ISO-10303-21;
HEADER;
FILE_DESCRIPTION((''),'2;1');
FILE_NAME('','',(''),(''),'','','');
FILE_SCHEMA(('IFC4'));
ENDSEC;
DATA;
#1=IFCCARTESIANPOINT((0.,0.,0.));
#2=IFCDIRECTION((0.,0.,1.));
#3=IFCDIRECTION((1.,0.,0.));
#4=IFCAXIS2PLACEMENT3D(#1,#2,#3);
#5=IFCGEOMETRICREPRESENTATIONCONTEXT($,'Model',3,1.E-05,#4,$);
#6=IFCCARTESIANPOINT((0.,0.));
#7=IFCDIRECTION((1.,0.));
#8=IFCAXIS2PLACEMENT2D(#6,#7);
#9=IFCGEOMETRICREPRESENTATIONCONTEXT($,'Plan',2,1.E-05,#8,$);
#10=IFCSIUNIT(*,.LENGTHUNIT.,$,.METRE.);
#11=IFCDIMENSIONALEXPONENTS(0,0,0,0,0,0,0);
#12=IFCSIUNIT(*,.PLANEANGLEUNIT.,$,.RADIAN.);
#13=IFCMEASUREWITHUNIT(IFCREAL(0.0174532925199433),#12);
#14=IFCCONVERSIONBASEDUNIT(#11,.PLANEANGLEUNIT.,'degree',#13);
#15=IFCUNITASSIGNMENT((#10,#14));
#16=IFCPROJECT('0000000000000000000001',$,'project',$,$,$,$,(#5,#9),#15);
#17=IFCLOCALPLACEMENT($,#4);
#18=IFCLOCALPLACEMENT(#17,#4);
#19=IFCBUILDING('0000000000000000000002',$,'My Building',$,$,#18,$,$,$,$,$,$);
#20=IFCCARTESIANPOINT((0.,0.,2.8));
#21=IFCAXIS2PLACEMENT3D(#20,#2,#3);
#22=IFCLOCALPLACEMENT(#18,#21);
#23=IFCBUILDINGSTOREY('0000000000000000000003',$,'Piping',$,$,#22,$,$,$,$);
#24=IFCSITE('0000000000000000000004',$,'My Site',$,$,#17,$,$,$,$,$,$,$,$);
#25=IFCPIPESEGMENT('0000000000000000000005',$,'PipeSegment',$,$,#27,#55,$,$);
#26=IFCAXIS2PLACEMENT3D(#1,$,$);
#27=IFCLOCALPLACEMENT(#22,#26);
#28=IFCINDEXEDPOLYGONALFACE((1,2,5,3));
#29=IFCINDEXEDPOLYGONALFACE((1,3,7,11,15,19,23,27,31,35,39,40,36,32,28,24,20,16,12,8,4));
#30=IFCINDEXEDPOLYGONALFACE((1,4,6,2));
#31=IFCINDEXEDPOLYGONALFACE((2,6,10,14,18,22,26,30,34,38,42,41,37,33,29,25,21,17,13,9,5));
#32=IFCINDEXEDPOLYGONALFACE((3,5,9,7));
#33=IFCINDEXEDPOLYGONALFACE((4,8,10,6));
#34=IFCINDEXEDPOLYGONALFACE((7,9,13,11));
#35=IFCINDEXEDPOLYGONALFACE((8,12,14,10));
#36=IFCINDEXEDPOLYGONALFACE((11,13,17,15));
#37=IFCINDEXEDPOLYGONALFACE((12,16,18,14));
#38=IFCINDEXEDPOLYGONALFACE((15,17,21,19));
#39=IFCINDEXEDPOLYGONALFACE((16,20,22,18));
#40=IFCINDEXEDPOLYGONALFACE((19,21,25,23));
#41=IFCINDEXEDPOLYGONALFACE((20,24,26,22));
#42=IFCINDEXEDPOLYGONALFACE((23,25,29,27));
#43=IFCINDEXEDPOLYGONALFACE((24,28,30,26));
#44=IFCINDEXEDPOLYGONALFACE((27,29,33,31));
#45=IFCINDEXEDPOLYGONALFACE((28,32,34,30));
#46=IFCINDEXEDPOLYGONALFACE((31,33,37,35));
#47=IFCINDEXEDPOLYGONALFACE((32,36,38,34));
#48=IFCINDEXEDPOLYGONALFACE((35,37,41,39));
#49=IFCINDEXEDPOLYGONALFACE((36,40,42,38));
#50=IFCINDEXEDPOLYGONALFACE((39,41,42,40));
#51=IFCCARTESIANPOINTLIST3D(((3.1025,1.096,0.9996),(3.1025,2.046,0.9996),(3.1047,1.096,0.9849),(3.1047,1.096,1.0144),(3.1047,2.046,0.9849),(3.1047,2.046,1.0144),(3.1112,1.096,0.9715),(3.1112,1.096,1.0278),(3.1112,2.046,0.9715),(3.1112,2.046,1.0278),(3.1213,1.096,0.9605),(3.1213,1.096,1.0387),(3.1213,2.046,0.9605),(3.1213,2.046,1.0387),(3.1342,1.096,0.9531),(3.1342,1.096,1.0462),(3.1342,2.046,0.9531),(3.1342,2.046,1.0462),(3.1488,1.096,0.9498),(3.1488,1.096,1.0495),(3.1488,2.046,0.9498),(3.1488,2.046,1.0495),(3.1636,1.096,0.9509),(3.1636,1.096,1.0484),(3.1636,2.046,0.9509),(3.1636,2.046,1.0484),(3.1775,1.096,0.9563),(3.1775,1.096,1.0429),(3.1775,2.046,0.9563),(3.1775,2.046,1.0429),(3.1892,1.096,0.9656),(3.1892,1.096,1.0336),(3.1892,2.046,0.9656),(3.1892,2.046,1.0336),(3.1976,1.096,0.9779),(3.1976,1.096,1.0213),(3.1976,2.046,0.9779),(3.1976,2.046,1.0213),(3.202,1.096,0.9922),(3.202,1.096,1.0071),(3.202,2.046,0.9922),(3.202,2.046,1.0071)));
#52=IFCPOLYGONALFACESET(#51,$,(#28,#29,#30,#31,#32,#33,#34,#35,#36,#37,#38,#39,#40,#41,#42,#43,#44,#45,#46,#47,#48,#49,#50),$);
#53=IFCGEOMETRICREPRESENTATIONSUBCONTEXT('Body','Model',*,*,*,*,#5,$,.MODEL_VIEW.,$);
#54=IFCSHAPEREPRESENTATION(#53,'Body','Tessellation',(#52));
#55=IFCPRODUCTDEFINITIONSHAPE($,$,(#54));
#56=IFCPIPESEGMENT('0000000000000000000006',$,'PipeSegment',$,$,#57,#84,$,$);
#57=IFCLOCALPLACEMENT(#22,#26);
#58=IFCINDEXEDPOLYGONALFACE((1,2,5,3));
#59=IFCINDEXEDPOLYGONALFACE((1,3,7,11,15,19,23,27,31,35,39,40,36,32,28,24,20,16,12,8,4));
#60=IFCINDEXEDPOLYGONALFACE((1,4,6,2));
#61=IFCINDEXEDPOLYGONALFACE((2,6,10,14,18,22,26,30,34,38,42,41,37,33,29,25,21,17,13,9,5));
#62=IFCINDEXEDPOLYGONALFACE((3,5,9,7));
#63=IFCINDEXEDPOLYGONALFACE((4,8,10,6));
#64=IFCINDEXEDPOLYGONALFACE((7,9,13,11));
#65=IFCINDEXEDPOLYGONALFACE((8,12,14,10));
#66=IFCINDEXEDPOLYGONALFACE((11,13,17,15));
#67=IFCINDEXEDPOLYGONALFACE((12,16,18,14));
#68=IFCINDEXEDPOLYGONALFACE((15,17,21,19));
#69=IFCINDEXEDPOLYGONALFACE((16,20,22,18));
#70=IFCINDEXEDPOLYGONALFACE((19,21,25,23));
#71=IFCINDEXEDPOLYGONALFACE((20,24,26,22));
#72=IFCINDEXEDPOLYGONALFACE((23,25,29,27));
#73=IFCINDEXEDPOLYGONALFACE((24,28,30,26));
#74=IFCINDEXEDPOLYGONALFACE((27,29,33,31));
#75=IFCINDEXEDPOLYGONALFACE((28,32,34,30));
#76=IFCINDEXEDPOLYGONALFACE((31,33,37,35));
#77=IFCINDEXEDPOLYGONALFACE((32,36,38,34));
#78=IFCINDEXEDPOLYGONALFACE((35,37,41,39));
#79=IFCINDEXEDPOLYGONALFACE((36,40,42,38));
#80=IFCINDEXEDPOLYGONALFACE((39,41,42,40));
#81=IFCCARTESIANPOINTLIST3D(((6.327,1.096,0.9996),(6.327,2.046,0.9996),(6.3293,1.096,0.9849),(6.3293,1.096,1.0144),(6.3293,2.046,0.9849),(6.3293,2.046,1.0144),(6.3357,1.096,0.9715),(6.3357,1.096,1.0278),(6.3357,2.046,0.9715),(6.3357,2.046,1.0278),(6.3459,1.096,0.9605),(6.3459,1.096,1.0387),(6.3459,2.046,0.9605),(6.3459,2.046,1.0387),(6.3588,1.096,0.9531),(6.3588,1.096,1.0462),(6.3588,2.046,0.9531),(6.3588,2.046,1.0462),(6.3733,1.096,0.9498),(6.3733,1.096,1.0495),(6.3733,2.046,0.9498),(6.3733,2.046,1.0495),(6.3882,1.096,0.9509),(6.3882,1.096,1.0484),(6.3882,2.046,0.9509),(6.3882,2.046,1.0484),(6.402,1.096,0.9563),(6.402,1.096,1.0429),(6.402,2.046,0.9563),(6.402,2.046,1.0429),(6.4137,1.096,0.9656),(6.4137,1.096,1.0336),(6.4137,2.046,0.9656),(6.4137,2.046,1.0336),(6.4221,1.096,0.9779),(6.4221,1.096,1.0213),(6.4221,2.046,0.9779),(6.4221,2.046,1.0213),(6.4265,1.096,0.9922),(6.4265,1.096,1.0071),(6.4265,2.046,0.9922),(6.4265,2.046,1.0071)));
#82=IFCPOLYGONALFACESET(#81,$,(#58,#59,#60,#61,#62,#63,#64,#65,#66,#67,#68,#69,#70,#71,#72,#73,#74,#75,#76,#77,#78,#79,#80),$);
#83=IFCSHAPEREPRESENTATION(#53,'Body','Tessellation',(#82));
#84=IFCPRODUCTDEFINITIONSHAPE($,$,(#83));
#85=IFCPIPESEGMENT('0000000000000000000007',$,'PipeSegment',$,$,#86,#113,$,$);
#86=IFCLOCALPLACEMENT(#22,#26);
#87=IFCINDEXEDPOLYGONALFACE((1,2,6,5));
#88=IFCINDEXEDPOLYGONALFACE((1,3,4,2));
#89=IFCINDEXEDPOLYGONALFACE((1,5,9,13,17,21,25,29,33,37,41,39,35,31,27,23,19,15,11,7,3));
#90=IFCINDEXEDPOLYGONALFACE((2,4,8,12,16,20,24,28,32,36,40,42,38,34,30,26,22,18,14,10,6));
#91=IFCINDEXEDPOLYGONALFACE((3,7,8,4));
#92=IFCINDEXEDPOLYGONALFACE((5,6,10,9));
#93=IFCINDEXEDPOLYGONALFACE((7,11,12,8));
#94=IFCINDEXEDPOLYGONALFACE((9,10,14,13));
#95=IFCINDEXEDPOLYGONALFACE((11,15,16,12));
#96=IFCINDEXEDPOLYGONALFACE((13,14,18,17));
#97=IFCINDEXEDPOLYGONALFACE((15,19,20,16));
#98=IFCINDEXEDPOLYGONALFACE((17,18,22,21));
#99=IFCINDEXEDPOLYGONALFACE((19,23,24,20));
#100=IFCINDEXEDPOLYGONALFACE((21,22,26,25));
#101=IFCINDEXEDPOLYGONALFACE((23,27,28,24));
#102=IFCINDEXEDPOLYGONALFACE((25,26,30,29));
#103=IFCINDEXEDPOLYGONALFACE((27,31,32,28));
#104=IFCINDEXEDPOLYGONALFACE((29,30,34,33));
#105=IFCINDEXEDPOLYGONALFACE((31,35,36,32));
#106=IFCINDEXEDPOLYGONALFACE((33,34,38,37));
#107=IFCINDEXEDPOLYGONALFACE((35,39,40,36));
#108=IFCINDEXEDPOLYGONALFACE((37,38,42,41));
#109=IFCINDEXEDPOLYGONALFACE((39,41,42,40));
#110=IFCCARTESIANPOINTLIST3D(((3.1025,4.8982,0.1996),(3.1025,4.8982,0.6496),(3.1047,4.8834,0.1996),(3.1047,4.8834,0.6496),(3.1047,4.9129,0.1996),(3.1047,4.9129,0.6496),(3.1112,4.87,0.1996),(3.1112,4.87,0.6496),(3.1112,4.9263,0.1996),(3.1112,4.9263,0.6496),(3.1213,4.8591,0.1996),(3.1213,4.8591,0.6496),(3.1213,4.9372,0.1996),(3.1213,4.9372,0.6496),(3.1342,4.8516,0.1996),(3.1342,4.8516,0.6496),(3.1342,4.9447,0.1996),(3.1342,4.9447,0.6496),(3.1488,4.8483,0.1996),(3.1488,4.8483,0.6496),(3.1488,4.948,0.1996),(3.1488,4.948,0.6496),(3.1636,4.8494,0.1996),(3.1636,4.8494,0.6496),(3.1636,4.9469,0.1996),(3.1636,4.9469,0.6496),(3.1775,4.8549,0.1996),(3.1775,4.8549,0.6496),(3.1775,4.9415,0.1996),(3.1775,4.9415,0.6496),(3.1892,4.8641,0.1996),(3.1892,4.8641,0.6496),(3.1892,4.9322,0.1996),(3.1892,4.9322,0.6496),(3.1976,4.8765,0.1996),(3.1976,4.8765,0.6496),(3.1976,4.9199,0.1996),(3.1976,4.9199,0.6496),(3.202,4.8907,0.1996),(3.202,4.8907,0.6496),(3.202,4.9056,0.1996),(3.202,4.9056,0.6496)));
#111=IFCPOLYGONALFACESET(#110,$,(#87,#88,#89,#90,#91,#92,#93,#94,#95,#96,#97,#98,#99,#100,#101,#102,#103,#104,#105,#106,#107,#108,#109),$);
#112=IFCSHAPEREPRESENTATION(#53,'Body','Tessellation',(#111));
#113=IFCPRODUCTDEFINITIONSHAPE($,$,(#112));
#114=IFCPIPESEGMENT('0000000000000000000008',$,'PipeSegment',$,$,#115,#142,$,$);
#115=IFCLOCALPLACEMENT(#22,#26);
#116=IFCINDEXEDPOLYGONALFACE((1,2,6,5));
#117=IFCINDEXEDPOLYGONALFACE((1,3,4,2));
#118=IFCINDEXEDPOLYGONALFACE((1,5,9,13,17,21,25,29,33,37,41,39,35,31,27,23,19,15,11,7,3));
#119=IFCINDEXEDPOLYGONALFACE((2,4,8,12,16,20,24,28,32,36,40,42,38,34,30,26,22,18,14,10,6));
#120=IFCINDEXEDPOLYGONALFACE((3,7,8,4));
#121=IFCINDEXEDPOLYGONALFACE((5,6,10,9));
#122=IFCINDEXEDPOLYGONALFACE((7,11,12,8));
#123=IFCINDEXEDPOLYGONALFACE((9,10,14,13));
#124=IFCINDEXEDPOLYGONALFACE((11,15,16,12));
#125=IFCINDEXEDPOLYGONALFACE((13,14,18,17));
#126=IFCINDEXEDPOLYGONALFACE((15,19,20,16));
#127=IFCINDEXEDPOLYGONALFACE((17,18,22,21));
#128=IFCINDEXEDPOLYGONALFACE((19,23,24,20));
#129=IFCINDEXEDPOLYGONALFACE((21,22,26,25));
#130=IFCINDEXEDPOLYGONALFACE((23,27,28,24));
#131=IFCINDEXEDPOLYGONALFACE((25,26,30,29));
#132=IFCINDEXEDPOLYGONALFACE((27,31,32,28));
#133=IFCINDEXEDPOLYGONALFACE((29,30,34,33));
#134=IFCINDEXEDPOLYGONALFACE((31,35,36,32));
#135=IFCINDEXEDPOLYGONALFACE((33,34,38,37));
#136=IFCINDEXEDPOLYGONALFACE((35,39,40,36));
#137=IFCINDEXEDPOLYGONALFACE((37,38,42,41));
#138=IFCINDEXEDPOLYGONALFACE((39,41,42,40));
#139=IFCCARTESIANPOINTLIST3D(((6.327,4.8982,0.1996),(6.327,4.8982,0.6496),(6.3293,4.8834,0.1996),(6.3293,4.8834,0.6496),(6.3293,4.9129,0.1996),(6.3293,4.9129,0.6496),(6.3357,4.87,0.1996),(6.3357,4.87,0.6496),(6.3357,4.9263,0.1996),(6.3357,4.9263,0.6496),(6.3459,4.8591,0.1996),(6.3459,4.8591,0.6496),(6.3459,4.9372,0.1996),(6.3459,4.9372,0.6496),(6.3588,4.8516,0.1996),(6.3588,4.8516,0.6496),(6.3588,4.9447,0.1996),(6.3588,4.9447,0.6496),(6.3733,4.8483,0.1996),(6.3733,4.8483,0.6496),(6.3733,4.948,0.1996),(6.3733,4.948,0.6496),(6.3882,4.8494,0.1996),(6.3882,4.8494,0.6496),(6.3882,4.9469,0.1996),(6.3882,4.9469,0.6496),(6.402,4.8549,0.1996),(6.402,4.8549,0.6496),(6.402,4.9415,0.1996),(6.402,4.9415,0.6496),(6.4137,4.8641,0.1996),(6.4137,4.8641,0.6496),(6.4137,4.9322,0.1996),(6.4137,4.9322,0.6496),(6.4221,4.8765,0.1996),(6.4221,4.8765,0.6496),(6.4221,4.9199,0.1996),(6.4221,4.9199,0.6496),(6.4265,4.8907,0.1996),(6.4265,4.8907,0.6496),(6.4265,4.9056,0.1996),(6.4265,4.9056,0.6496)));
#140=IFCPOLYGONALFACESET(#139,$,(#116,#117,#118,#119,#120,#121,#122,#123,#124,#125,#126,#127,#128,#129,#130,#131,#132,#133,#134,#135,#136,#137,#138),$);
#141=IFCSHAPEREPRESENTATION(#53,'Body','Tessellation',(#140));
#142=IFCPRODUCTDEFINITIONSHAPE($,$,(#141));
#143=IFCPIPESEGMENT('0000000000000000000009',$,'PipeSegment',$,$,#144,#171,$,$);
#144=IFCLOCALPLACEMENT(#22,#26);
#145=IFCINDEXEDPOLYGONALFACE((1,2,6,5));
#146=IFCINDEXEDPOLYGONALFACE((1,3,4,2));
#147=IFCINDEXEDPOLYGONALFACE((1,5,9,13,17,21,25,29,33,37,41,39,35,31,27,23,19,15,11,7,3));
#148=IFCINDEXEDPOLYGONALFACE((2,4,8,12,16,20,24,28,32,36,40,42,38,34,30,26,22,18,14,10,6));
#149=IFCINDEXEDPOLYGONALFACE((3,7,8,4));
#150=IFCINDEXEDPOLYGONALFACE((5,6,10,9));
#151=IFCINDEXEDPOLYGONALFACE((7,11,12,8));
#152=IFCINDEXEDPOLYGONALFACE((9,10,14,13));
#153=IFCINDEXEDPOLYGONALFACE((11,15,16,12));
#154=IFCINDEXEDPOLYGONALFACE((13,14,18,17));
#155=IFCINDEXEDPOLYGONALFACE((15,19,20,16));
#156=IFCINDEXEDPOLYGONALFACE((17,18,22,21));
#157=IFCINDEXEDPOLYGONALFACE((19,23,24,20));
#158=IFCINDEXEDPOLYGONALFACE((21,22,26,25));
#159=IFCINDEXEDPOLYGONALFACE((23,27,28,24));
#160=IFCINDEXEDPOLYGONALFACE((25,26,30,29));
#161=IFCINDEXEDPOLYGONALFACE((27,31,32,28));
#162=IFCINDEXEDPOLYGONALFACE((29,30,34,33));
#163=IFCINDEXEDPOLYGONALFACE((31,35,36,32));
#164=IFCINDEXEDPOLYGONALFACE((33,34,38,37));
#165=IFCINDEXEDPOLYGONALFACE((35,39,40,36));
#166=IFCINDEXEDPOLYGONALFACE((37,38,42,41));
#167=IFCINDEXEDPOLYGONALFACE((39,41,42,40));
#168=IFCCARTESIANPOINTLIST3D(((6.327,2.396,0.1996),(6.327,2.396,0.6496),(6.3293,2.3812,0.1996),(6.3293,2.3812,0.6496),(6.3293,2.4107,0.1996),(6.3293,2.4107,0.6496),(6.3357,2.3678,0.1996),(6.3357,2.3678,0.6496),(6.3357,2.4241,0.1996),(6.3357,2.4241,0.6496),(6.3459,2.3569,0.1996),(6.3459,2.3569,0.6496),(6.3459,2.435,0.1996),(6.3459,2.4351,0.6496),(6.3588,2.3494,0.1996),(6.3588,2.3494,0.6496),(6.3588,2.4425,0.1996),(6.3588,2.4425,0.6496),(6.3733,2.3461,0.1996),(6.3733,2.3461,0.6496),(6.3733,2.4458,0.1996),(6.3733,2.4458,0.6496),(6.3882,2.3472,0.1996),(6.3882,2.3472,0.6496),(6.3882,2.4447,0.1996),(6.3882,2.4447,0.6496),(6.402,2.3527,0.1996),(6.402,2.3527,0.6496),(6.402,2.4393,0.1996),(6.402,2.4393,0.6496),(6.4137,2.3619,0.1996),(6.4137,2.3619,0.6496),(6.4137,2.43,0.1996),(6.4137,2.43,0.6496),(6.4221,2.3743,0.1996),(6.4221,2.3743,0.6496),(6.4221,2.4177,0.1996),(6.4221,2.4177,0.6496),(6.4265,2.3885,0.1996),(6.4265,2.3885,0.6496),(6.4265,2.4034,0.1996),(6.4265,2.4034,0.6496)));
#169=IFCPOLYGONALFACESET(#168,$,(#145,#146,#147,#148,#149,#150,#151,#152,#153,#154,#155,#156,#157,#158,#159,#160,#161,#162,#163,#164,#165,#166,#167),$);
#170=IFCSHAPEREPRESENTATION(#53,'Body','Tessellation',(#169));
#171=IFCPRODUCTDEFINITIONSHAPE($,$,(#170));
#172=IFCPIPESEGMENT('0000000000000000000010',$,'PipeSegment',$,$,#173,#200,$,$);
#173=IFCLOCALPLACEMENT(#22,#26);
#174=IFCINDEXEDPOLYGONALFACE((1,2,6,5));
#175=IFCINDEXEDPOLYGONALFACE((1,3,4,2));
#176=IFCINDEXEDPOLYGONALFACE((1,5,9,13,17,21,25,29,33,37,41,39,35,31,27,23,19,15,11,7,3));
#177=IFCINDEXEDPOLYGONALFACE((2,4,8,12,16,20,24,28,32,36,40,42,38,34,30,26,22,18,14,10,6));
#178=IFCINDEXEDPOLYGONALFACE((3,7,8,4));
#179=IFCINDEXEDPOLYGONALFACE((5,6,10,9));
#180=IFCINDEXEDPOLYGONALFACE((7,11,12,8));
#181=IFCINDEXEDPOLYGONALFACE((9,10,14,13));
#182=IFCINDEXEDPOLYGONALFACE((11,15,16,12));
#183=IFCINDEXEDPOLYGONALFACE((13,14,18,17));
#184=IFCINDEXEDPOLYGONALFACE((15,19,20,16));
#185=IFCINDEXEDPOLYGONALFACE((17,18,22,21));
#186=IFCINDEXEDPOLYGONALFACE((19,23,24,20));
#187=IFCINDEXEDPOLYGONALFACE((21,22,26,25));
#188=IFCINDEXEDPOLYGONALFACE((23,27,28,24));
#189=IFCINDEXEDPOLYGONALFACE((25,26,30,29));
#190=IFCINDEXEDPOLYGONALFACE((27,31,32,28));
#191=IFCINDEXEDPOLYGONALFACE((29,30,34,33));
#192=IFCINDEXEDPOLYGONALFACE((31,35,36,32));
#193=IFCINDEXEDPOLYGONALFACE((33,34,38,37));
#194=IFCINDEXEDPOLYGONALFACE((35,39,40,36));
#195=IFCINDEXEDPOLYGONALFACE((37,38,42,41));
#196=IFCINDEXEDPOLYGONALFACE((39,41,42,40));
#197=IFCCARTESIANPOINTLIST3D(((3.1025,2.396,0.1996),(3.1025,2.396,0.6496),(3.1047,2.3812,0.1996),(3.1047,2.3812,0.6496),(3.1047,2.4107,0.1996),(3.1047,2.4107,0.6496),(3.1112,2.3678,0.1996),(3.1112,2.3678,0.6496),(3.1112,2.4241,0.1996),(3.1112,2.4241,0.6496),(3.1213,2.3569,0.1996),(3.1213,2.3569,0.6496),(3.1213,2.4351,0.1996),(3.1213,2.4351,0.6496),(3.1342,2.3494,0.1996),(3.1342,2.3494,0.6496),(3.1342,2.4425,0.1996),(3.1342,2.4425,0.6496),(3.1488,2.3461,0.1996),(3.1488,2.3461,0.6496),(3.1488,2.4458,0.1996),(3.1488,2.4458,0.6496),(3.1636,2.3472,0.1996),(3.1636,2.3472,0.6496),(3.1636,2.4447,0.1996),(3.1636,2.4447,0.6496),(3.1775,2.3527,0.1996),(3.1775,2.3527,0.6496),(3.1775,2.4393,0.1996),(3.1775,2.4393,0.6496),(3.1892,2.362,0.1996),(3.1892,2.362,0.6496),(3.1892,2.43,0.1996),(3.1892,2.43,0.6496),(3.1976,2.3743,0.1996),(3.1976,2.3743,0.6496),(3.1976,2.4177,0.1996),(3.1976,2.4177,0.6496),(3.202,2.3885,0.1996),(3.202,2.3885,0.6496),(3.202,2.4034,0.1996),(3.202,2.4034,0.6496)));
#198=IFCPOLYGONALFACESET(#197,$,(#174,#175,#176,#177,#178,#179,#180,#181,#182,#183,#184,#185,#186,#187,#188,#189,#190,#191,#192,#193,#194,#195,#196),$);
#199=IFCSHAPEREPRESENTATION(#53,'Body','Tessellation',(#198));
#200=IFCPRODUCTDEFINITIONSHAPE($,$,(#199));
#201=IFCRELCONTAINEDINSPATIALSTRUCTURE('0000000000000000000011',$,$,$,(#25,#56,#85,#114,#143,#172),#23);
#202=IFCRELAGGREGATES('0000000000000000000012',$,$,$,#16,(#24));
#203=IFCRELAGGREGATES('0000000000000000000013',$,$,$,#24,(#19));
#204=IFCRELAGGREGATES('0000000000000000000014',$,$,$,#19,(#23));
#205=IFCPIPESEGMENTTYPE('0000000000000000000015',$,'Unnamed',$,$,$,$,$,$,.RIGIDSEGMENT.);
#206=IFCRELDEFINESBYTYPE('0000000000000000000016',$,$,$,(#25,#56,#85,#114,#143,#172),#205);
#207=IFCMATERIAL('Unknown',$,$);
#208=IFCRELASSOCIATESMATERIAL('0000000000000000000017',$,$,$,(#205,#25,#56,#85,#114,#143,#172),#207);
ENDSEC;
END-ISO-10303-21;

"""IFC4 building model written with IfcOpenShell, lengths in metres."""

from ifc_helpers import new_model, entity, si_unit, converted_unit, frame, origin_with_axes, origin_2d_with_axis, place, context, subcontext, project, spatial, circle, extrude, material, material_profile, profile_set, profile_usage, type_object, element, save


model = new_model("IFC4")

# Units and contexts
model_context = context("Model", 3, precision=1e-05, world=origin_with_axes())
plan_context = context("Plan", 2, precision=1e-05, world=origin_2d_with_axis())
body_context = subcontext(model_context, "Body", "Model", "MODEL_VIEW")
ifc_project = project(units=[si_unit("LENGTHUNIT", "METRE"), converted_unit("PLANEANGLEUNIT", "degree", entity("IfcReal", 0.0174532925199433), si_unit("PLANEANGLEUNIT", "RADIAN"), dimensions=[0, 0, 0, 0, 0, 0, 0])], contexts=[model_context, plan_context])

# Site, building, storey
site_placement = place(None, origin_with_axes())
site = spatial("IfcSite", under=ifc_project, at=site_placement, Name="My Site")
building_placement = place(site_placement, origin_with_axes())
building = spatial("IfcBuilding", under=site, at=building_placement, Name="My Building")
storey_placement = place(building_placement, frame((0.0, 0.0, 2.8), z_axis=(0.0, 0.0, 1.0), x_axis=(1.0, 0.0, 0.0)))
storey = spatial("IfcBuildingStorey", under=building, at=storey_placement, Name="Piping")

# Pipe segments
ifc_material = material(Name="Unknown")
ifc_material_profile_1 = material_profile(ifc_material, circle(Radius=0.05))
ifc_profile_set_1 = profile_set([ifc_material_profile_1])
pipe_segment_type = type_object("IfcPipeSegmentType", Name="Unnamed", PredefinedType="RIGIDSEGMENT", material=ifc_profile_set_1)
ifc_profile_usage_1 = profile_usage(ifc_profile_set_1, cardinal=5)
pipe_segment_1_placement = place(storey_placement, frame((3.1525, 1.096, 0.9996), z_axis=(0.0, 1.0, 0.0), x_axis=(-1.0, 0.0, 0.0)))
element("IfcPipeSegment", 1, at=pipe_segment_1_placement, inside=storey, type_object=pipe_segment_type, material=ifc_profile_usage_1, Name="PipeSegment", context=body_context, shape_type="SweptSolid", body=[
    extrude(circle(Radius=0.05), origin_with_axes(), (0.0, 0.0, 1.0), 0.95),
])
ifc_profile_usage_2 = profile_usage(ifc_profile_set_1, cardinal=5)
pipe_segment_2_placement = place(storey_placement, frame((6.377, 1.096, 0.9996), z_axis=(0.0, 1.0, 0.0), x_axis=(-1.0, 0.0, 0.0)))
element("IfcPipeSegment", 2, at=pipe_segment_2_placement, inside=storey, type_object=pipe_segment_type, material=ifc_profile_usage_2, Name="PipeSegment", context=body_context, shape_type="SweptSolid", body=[
    extrude(circle(Radius=0.05), origin_with_axes(), (0.0, 0.0, 1.0), 0.95),
])
ifc_profile_usage_3 = profile_usage(ifc_profile_set_1, cardinal=5)
pipe_segment_3_placement = place(storey_placement, frame((3.1525, 4.8982, 0.6496), z_axis=(0.0, 0.0, -1.0), x_axis=(-1.0, 0.0, 0.0)))
element("IfcPipeSegment", 3, at=pipe_segment_3_placement, inside=storey, type_object=pipe_segment_type, material=ifc_profile_usage_3, Name="PipeSegment", context=body_context, shape_type="SweptSolid", body=[
    extrude(circle(Radius=0.05), origin_with_axes(), (0.0, 0.0, 1.0), 0.45),
])
ifc_profile_usage_4 = profile_usage(ifc_profile_set_1, cardinal=5)
pipe_segment_4_placement = place(storey_placement, frame((6.377, 4.8982, 0.6496), z_axis=(0.0, 0.0, -1.0), x_axis=(-1.0, 0.0, 0.0)))
element("IfcPipeSegment", 4, at=pipe_segment_4_placement, inside=storey, type_object=pipe_segment_type, material=ifc_profile_usage_4, Name="PipeSegment", context=body_context, shape_type="SweptSolid", body=[
    extrude(circle(Radius=0.05), origin_with_axes(), (0.0, 0.0, 1.0), 0.45),
])
ifc_profile_usage_5 = profile_usage(ifc_profile_set_1, cardinal=5)
pipe_segment_5_placement = place(storey_placement, frame((6.377, 2.396, 0.6496), z_axis=(0.0, 0.0, -1.0), x_axis=(-1.0, 0.0, 0.0)))
element("IfcPipeSegment", 5, at=pipe_segment_5_placement, inside=storey, type_object=pipe_segment_type, material=ifc_profile_usage_5, Name="PipeSegment", context=body_context, shape_type="SweptSolid", body=[
    extrude(circle(Radius=0.05), origin_with_axes(), (0.0, 0.0, 1.0), 0.45),
])
ifc_profile_usage_6 = profile_usage(ifc_profile_set_1, cardinal=5)
pipe_segment_6_placement = place(storey_placement, frame((3.1525, 2.396, 0.6496), z_axis=(0.0, 0.0, -1.0), x_axis=(-1.0, 0.0, 0.0)))
element("IfcPipeSegment", 6, at=pipe_segment_6_placement, inside=storey, type_object=pipe_segment_type, material=ifc_profile_usage_6, Name="PipeSegment", context=body_context, shape_type="SweptSolid", body=[
    extrude(circle(Radius=0.05), origin_with_axes(), (0.0, 0.0, 1.0), 0.45),
])

save(model, "model.ifc")
